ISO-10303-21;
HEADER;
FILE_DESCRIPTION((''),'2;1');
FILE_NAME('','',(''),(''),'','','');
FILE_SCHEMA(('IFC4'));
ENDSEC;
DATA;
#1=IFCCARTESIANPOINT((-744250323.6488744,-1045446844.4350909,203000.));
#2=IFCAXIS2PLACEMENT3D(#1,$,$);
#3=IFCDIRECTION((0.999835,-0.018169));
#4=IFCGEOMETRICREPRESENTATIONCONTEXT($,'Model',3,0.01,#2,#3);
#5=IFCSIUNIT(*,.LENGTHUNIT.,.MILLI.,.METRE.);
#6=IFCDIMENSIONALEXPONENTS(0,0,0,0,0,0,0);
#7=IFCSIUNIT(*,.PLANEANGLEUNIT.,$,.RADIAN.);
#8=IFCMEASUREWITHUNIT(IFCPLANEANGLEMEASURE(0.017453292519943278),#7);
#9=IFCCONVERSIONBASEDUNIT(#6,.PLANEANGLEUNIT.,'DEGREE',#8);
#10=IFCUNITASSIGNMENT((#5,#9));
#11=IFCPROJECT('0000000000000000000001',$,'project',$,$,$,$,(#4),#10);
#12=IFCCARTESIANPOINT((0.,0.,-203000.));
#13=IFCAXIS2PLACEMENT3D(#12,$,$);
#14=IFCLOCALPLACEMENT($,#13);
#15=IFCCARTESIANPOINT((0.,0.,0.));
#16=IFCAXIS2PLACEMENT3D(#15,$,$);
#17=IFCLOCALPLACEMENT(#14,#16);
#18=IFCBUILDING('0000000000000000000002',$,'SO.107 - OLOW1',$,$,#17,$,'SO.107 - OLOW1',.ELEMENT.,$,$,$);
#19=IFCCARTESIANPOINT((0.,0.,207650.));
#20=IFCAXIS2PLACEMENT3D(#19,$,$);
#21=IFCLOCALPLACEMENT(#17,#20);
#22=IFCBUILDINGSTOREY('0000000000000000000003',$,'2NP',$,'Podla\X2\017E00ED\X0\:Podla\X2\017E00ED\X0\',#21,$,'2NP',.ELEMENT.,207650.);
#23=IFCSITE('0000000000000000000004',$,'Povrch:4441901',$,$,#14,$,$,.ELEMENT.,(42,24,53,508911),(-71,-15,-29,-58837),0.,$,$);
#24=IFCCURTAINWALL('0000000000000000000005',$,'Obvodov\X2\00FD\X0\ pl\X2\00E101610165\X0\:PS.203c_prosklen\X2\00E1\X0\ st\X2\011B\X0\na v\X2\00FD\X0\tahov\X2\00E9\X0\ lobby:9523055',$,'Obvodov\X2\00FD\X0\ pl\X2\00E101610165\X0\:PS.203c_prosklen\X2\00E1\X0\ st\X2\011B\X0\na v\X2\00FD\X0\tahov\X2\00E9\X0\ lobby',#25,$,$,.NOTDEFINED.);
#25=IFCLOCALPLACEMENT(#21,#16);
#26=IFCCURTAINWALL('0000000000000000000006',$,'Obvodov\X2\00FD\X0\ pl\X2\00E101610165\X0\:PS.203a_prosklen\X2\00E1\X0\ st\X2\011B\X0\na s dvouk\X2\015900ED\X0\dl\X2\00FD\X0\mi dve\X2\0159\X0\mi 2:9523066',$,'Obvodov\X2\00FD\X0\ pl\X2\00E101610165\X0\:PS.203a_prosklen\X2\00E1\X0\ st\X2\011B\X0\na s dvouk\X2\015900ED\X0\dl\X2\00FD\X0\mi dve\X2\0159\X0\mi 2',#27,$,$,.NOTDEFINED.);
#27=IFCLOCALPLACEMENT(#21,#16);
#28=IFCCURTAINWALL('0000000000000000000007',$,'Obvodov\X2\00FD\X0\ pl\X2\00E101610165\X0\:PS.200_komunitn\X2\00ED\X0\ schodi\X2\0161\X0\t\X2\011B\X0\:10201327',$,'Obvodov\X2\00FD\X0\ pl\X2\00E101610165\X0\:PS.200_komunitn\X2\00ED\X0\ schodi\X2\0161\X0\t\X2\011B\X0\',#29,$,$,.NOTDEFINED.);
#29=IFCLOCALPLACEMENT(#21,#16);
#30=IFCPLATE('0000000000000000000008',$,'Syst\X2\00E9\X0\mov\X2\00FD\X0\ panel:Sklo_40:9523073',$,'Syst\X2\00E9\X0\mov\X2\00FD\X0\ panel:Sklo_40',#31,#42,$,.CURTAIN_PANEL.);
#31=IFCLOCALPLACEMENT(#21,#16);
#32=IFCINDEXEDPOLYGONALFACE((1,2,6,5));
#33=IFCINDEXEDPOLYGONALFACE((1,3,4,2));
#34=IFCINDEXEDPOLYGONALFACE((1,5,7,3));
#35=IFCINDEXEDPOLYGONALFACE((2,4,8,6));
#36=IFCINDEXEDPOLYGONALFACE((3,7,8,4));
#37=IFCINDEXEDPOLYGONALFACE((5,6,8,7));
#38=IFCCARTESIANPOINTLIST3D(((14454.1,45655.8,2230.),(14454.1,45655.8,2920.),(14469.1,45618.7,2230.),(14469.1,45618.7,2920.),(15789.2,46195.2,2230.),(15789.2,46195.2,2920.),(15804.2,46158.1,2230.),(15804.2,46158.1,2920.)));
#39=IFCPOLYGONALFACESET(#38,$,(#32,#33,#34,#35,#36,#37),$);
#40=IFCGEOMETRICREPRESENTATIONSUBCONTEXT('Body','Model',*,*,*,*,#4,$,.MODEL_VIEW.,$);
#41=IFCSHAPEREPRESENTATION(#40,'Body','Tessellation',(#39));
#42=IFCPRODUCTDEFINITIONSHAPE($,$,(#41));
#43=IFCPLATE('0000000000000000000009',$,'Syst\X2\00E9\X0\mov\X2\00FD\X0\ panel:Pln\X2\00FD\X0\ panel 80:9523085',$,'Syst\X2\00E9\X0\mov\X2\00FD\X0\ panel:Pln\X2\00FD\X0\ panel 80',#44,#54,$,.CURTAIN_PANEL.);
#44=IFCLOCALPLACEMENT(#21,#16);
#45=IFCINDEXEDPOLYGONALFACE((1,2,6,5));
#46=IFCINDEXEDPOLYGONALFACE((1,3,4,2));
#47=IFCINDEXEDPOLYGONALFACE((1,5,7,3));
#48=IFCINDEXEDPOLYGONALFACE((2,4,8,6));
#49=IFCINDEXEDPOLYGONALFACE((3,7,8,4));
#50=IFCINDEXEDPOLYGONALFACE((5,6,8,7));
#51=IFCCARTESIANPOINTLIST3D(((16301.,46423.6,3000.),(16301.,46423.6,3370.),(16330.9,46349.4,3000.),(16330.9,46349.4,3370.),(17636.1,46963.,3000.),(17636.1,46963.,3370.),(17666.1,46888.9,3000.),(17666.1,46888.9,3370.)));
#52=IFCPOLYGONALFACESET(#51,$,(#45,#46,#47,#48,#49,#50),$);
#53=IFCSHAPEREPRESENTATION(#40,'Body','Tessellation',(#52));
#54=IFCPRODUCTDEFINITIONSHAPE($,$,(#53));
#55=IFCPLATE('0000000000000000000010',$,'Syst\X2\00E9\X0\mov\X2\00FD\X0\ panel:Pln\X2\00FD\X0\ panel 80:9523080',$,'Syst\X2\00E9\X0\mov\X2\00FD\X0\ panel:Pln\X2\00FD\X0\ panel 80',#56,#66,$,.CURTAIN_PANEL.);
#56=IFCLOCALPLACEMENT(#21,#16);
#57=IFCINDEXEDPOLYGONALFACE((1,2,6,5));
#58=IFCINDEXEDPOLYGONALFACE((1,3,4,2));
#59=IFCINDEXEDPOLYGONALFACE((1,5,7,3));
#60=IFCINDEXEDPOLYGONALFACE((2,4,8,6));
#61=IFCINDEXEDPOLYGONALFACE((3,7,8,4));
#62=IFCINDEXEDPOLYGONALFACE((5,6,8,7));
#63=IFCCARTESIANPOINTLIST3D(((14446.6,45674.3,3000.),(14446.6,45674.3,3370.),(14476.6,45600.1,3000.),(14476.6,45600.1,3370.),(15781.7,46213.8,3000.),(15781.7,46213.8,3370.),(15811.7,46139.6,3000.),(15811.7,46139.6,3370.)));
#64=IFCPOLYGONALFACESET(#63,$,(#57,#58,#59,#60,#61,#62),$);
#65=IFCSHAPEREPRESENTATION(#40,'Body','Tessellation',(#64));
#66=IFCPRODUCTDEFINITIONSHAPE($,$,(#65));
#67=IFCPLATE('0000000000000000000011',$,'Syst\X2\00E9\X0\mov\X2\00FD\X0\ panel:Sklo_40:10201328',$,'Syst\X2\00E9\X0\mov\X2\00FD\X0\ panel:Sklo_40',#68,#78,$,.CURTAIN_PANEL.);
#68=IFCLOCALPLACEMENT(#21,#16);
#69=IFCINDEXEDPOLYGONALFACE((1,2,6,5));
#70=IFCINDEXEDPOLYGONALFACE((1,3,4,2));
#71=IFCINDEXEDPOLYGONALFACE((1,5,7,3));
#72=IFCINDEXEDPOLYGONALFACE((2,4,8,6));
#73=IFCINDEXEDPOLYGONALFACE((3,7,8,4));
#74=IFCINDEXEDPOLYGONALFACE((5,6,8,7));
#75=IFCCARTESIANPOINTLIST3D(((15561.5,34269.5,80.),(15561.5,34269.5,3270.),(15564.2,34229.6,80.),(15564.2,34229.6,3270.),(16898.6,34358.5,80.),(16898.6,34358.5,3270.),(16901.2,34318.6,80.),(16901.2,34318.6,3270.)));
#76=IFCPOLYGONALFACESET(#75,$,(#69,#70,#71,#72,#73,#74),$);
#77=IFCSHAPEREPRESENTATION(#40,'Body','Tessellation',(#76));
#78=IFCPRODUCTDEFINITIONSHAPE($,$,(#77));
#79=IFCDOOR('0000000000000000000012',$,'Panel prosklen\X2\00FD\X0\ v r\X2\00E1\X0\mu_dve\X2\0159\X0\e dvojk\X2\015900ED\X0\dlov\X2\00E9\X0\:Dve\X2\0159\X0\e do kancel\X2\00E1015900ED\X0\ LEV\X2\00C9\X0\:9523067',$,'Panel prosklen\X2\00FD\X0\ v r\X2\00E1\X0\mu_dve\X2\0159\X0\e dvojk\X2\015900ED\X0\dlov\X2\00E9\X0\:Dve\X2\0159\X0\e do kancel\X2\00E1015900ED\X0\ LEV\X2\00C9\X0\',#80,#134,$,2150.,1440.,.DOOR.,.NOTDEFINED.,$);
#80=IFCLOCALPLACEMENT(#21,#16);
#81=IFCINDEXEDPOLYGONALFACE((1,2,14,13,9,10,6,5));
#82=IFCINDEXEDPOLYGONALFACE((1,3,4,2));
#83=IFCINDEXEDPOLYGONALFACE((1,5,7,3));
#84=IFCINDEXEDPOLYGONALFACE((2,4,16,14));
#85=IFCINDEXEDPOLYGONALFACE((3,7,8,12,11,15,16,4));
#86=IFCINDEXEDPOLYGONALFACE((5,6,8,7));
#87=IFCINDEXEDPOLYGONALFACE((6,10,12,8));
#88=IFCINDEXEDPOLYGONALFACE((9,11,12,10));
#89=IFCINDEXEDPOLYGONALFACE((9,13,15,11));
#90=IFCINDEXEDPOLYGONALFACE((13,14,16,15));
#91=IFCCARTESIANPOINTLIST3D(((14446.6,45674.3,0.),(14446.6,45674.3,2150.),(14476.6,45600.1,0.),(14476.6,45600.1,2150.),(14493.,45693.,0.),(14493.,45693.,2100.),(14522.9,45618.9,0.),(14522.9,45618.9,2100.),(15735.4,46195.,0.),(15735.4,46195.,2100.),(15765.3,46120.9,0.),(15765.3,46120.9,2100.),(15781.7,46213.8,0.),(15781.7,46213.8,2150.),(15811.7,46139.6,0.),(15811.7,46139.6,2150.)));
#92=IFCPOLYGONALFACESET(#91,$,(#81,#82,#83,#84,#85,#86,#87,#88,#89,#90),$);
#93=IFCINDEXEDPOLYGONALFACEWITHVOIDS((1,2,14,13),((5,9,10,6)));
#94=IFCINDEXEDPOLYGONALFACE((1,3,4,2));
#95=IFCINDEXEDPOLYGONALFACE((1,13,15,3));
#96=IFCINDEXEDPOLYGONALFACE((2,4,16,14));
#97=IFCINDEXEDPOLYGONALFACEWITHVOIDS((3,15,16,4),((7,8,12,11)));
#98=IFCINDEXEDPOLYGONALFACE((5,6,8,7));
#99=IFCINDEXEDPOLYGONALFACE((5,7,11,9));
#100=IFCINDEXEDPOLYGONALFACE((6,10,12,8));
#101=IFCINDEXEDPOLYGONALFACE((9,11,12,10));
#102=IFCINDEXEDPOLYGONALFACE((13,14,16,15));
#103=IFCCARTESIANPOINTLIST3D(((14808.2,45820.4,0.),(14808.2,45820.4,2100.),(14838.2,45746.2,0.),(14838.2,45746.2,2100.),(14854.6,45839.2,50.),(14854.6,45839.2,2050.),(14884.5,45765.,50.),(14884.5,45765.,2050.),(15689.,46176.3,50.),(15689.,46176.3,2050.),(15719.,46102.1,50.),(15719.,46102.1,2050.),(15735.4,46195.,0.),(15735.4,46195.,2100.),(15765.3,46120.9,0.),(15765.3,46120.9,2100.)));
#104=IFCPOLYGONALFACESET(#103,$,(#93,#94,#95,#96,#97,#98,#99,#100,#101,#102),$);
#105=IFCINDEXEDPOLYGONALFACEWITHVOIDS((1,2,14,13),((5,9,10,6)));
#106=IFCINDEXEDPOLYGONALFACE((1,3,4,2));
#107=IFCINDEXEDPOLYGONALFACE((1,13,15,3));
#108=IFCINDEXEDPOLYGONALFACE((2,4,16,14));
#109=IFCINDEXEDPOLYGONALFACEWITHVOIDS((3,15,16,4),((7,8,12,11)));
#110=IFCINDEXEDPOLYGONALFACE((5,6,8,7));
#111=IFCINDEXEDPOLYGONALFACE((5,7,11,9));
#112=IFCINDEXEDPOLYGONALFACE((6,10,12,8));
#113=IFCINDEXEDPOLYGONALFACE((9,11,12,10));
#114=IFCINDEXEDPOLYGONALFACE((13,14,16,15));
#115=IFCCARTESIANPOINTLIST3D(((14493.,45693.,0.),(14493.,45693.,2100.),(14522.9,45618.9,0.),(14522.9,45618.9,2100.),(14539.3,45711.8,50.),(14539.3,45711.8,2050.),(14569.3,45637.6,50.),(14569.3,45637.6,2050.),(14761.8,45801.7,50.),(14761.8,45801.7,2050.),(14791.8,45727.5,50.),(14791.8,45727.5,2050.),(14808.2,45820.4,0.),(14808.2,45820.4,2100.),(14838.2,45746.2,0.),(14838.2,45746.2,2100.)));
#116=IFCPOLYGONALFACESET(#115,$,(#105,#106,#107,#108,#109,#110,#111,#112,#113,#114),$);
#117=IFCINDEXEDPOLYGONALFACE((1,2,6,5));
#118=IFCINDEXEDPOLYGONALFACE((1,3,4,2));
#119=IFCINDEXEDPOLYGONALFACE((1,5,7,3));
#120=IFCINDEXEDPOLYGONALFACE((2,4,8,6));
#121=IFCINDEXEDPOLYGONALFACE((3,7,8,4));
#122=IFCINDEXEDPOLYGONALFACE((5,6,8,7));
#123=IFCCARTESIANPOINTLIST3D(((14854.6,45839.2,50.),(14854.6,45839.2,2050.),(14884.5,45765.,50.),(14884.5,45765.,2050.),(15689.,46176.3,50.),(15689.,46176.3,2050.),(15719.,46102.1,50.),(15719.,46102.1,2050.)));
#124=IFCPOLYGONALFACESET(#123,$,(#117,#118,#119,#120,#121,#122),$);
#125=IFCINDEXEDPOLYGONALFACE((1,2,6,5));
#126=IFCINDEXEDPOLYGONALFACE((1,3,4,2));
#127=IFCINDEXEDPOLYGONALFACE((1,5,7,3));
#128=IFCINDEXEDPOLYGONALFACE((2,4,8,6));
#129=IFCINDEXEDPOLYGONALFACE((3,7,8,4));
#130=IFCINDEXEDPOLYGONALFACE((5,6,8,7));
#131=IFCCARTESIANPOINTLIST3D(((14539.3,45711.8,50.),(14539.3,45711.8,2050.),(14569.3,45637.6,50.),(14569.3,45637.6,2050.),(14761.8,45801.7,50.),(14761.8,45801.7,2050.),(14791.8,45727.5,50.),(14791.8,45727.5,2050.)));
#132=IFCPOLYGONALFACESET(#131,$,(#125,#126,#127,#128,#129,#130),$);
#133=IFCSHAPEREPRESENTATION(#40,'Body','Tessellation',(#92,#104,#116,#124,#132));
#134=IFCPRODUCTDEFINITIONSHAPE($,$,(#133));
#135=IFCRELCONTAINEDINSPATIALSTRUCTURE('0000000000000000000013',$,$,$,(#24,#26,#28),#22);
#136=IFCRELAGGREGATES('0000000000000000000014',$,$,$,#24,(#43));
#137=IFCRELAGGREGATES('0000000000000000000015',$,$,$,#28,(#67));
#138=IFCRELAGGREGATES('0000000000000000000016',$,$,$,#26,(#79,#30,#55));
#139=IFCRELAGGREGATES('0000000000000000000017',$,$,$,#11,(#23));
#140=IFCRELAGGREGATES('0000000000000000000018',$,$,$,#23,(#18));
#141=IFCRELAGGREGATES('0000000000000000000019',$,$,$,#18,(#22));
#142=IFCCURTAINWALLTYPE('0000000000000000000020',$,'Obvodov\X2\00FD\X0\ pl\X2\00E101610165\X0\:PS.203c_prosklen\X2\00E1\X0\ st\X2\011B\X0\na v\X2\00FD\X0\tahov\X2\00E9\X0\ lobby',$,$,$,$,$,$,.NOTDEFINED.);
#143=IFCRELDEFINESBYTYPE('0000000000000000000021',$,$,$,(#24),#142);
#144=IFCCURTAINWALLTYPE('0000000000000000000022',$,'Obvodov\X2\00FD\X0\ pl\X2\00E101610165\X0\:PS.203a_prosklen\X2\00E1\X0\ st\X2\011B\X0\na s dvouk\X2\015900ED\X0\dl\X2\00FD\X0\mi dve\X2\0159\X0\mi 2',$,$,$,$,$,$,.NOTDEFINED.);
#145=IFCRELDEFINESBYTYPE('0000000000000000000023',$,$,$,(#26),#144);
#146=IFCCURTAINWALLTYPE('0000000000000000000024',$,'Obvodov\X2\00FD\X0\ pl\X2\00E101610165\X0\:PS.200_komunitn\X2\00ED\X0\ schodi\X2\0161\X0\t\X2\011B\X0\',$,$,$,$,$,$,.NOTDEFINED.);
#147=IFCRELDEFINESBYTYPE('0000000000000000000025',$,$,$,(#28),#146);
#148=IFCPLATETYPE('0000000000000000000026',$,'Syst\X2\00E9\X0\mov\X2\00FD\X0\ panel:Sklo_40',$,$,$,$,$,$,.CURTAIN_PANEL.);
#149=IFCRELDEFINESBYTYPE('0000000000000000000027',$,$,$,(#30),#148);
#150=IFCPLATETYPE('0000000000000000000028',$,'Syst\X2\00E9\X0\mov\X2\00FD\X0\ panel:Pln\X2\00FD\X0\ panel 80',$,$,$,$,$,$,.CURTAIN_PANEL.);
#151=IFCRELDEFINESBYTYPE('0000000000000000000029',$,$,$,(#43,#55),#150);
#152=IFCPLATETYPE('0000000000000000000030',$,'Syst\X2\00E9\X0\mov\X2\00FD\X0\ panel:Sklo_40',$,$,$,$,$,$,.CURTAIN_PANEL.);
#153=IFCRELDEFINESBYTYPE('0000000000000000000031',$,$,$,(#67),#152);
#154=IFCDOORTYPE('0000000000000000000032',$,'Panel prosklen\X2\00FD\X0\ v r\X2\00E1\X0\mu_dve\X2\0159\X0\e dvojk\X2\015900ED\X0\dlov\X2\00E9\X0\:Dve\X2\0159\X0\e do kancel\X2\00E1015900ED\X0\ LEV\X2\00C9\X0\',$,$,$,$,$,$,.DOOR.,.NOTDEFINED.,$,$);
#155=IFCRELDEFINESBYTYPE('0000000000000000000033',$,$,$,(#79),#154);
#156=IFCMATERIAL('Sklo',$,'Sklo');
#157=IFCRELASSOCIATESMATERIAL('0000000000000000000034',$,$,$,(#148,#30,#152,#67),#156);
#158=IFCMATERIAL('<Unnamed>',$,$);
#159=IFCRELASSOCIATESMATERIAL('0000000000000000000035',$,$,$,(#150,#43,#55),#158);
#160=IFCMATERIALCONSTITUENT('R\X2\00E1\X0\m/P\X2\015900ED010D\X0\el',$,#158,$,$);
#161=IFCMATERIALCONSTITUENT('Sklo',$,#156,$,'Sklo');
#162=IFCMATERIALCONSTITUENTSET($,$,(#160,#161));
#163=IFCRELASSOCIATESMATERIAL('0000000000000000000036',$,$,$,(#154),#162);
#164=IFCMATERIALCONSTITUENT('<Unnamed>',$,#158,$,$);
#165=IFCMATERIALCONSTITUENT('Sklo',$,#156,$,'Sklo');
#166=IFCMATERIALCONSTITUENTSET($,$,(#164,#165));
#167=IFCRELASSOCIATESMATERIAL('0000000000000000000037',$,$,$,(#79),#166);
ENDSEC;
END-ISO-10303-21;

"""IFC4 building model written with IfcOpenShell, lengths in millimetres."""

from ifc_helpers import new_model, entity, si_unit, converted_unit, direction, frame, origin, place, context, subcontext, project, spatial, indexed_curve, outline, extrude, source, transform, mapped, material, constituent, constituent_set, type_object, type_shapes, element, aggregate, save


model = new_model("IFC4")

# Units and contexts
model_context = context("Model", 3, precision=0.01, world=frame((-744250323.6488744, -1045446844.4350909, 203000.0)), true_north=direction((0.999835, -0.018169)))
body_context = subcontext(model_context, "Body", "Model", "MODEL_VIEW")
ifc_project = project(units=[si_unit("LENGTHUNIT", "METRE", prefix="MILLI"), converted_unit("PLANEANGLEUNIT", "DEGREE", entity("IfcPlaneAngleMeasure", 0.017453292519943278), si_unit("PLANEANGLEUNIT", "RADIAN"), dimensions=[0, 0, 0, 0, 0, 0, 0])], contexts=[model_context])

# Site, building, storey
site_placement = place(None, frame((0.0, 0.0, -203000.0)))
site = spatial("IfcSite", under=ifc_project, at=site_placement, Name="Povrch:4441901", CompositionType="ELEMENT", RefLatitude=(42, 24, 53, 508911), RefLongitude=(-71, -15, -29, -58837), RefElevation=0.0)
building_placement = place(site_placement, origin())
building = spatial("IfcBuilding", under=site, at=building_placement, Name="SO.107 - OLOW1", LongName="SO.107 - OLOW1", CompositionType="ELEMENT")
storey_placement = place(building_placement, frame((0.0, 0.0, 207650.0)))
storey = spatial("IfcBuildingStorey", under=building, at=storey_placement, Name="2NP", ObjectType="Podlaží:Podlaží", LongName="2NP", CompositionType="ELEMENT", Elevation=207650.0)

# Curtain wall
curtain_wall_type_1 = type_object("IfcCurtainWallType", Name="Obvodový plášť:PS.203c_prosklená stěna výtahové lobby", PredefinedType="NOTDEFINED")
curtain_wall_1_placement = place(storey_placement, frame((0.0, 0.0, -207650.0)))
curtain_wall_1 = element("IfcCurtainWall", 1, at=curtain_wall_1_placement, inside=storey, type_object=curtain_wall_type_1, Name="Obvodový plášť:PS.203c_prosklená stěna výtahové lobby:9523055", ObjectType="Obvodový plášť:PS.203c_prosklená stěna výtahové lobby", PredefinedType="NOTDEFINED")
ifc_material_1 = material(Name="<Unnamed>")

# Curtain wall
curtain_wall_type_2 = type_object("IfcCurtainWallType", Name="Obvodový plášť:PS.203a_prosklená stěna s dvoukřídlými dveřmi 2", PredefinedType="NOTDEFINED")
curtain_wall_2_placement = place(storey_placement, frame((0.0, 0.0, -207650.0)))
curtain_wall_2 = element("IfcCurtainWall", 2, at=curtain_wall_2_placement, inside=storey, type_object=curtain_wall_type_2, Name="Obvodový plášť:PS.203a_prosklená stěna s dvoukřídlými dveřmi 2:9523066", ObjectType="Obvodový plášť:PS.203a_prosklená stěna s dvoukřídlými dveřmi 2", PredefinedType="NOTDEFINED")

# Curtain wall
curtain_wall_type_3 = type_object("IfcCurtainWallType", Name="Obvodový plášť:PS.200_komunitní schodiště", PredefinedType="NOTDEFINED")
curtain_wall_3_placement = place(storey_placement, frame((0.0, 0.0, -207650.0)))
curtain_wall_3 = element("IfcCurtainWall", 3, at=curtain_wall_3_placement, inside=storey, type_object=curtain_wall_type_3, Name="Obvodový plášť:PS.200_komunitní schodiště:10201327", ObjectType="Obvodový plášť:PS.200_komunitní schodiště", PredefinedType="NOTDEFINED")

# Plates
ifc_material_2 = material(Name="Sklo", Category="Sklo")
plate_type_1 = type_object("IfcPlateType", Name="Systémový panel:Sklo_40", PredefinedType="CURTAIN_PANEL", material=ifc_material_2)
shared_shape_1 = source(origin(), body_context, "Body", "SweptSolid", [
    extrude(outline(indexed_curve([(-20.0, -720.0), (20.0, -720.0), (20.0, 720.0), (-20.0, 720.0), (-20.0, -720.0)], self_intersect=False)), frame((0.0, 0.0, 0.0), z_axis=(0.0, 0.0, 1.0), x_axis=(0.0, 1.0, 0.0)), (0.0, 0.0, 1.0), 690.0),
])
type_shapes(plate_type_1, [shared_shape_1])
plate_1_placement = place(curtain_wall_2_placement, frame((15129.2, 45907.0, 209880.0), z_axis=(0.0, 0.0, 1.0), x_axis=(0.927176, 0.374626, 0.0)))
plate_1 = element("IfcPlate", 4, at=plate_1_placement, type_object=plate_type_1, material=ifc_material_2, Name="Systémový panel:Sklo_40:9523073", ObjectType="Systémový panel:Sklo_40", PredefinedType="CURTAIN_PANEL", context=body_context, shape_type="MappedRepresentation", body=[
    mapped(shared_shape_1, transform((0.0, 0.0, 0.0), scale=1.0)),
])
plate_type_2 = type_object("IfcPlateType", Name="Systémový panel:Plný panel 80", PredefinedType="CURTAIN_PANEL", material=ifc_material_1)
shared_shape_2 = source(origin(), body_context, "Body", "SweptSolid", [
    extrude(outline(indexed_curve([(-40.0, -720.0), (40.0, -720.0), (40.0, 720.0), (-40.0, 720.0), (-40.0, -720.0)], self_intersect=False)), frame((0.0, 0.0, 0.0), z_axis=(0.0, 0.0, 1.0), x_axis=(0.0, 1.0, 0.0)), (0.0, 0.0, 1.0), 370.0),
])
type_shapes(plate_type_2, [shared_shape_2])
plate_2_placement = place(curtain_wall_1_placement, frame((16983.5, 46656.2, 210650.0), z_axis=(0.0, 0.0, 1.0), x_axis=(0.927176, 0.374626, 0.0)))
plate_2 = element("IfcPlate", 5, at=plate_2_placement, type_object=plate_type_2, material=ifc_material_1, Name="Systémový panel:Plný panel 80:9523085", ObjectType="Systémový panel:Plný panel 80", PredefinedType="CURTAIN_PANEL", context=body_context, shape_type="MappedRepresentation", body=[
    mapped(shared_shape_2, transform((0.0, 0.0, 0.0), scale=1.0)),
])
aggregate(curtain_wall_1, [plate_2])
plate_3_placement = place(curtain_wall_2_placement, frame((15129.2, 45907.0, 210650.0), z_axis=(0.0, 0.0, 1.0), x_axis=(0.927176, 0.374626, 0.0)))
plate_3 = element("IfcPlate", 6, at=plate_3_placement, type_object=plate_type_2, material=ifc_material_1, Name="Systémový panel:Plný panel 80:9523080", ObjectType="Systémový panel:Plný panel 80", PredefinedType="CURTAIN_PANEL", context=body_context, shape_type="MappedRepresentation", body=[
    mapped(shared_shape_2, transform((0.0, 0.0, 0.0), scale=1.0)),
])

# Plate
plate_type_3 = type_object("IfcPlateType", Name="Systémový panel:Sklo_40", PredefinedType="CURTAIN_PANEL", material=ifc_material_2)
shared_shape_3 = source(origin(), body_context, "Body", "SweptSolid", [
    extrude(outline(indexed_curve([(-20.0, -670.0), (20.0, -670.0), (20.0, 670.0), (-20.0, 670.0), (-20.0, -670.0)], self_intersect=False)), frame((0.0, 0.0, 0.0), z_axis=(0.0, 0.0, 1.0), x_axis=(0.0, 1.0, 0.0)), (0.0, 0.0, 1.0), 3190.0),
])
type_shapes(plate_type_3, [shared_shape_3])
plate_4_placement = place(curtain_wall_3_placement, frame((16231.4, 34294.0, 207730.0), z_axis=(0.0, 0.0, 1.0), x_axis=(-0.997792, -0.066409, 0.0)))
plate_4 = element("IfcPlate", 7, at=plate_4_placement, type_object=plate_type_3, material=ifc_material_2, Name="Systémový panel:Sklo_40:10201328", ObjectType="Systémový panel:Sklo_40", PredefinedType="CURTAIN_PANEL", context=body_context, shape_type="MappedRepresentation", body=[
    mapped(shared_shape_3, transform((0.0, 0.0, 0.0), scale=1.0)),
])
aggregate(curtain_wall_3, [plate_4])

# Door
ifc_constituent_1 = constituent(ifc_material_1, Name="<Unnamed>")
ifc_constituent_2 = constituent(ifc_material_2, Name="Sklo", Category="Sklo")
ifc_constituent_set_1 = constituent_set(constituents=[ifc_constituent_1, ifc_constituent_2])
ifc_constituent_3 = constituent(ifc_material_1, Name="Rám/Příčel")
ifc_constituent_4 = constituent(ifc_material_2, Name="Sklo", Category="Sklo")
ifc_constituent_set_2 = constituent_set(constituents=[ifc_constituent_3, ifc_constituent_4])
door_type = type_object("IfcDoorType", Name="Panel prosklený v rámu_dveře dvojkřídlové:Dveře do kanceláří LEVÉ", OperationType="NOTDEFINED", PredefinedType="DOOR", material=ifc_constituent_set_2)
shared_shape_4 = source(origin(), body_context, "Body", "SweptSolid", [
    extrude(outline(indexed_curve([(-720.0, -1087.5), (720.0, -1087.5), (720.0, 1062.5), (670.0, 1062.5), (670.0, -1037.5), (-670.0, -1037.5), (-670.0, 1062.5), (-720.0, 1062.5), (-720.0, -1087.5)], self_intersect=False)), frame((0.0, 40.0, 1062.5), z_axis=(0.0, -1.0, 0.0), x_axis=(-1.0, 0.0, 0.0)), (0.0, 0.0, 1.0), 80.0),
    extrude(outline(indexed_curve([(-1050.0, -500.0), (1050.0, -500.0), (1050.0, 500.0), (-1050.0, 500.0), (-1050.0, -500.0)], self_intersect=False), holes=[indexed_curve([(-1000.0, -450.0), (-1000.0, 450.0), (1000.0, 450.0), (1000.0, -450.0), (-1000.0, -450.0)], self_intersect=False)]), frame((-170.0, 40.0, 1050.0), z_axis=(0.0, -1.0, 0.0), x_axis=(0.0, 0.0, -1.0)), (0.0, 0.0, 1.0), 80.0),
    extrude(outline(indexed_curve([(-1050.0, -170.0), (1050.0, -170.0), (1050.0, 170.0), (-1050.0, 170.0), (-1050.0, -170.0)], self_intersect=False), holes=[indexed_curve([(-1000.0, -120.0), (-1000.0, 120.0), (1000.0, 120.0), (1000.0, -120.0), (-1000.0, -120.0)], self_intersect=False)]), frame((500.0, 40.0, 1050.0), z_axis=(0.0, -1.0, 0.0), x_axis=(0.0, 0.0, -1.0)), (0.0, 0.0, 1.0), 80.0),
    extrude(outline(indexed_curve([(-450.0, -40.0), (450.0, -40.0), (450.0, 40.0), (-450.0, 40.0), (-450.0, -40.0)], self_intersect=False)), frame((-170.0, 0.0, 50.0)), (0.0, 0.0, 1.0), 2000.0),
    extrude(outline(indexed_curve([(-120.0, -40.0), (120.0, -40.0), (120.0, 40.0), (-120.0, 40.0), (-120.0, -40.0)], self_intersect=False)), frame((500.0, 0.0, 50.0)), (0.0, 0.0, 1.0), 2000.0),
])
type_shapes(door_type, [shared_shape_4])
door_placement = place(curtain_wall_2_placement, frame((15129.2, 45907.0, 207650.0), z_axis=(0.0, 0.0, 1.0), x_axis=(-0.927176, -0.374626, 0.0)))
door = element("IfcDoor", 8, at=door_placement, type_object=door_type, material=ifc_constituent_set_1, Name="Panel prosklený v rámu_dveře dvojkřídlové:Dveře do kanceláří LEVÉ:9523067", ObjectType="Panel prosklený v rámu_dveře dvojkřídlové:Dveře do kanceláří LEVÉ", OperationType="NOTDEFINED", OverallHeight=2150.0, OverallWidth=1440.0, PredefinedType="DOOR", context=body_context, shape_type="MappedRepresentation", body=[
    mapped(shared_shape_4, transform((0.0, 0.0, 0.0), scale=1.0)),
])
aggregate(curtain_wall_2, [door, plate_1, plate_3])

save(model, "model.ifc")
